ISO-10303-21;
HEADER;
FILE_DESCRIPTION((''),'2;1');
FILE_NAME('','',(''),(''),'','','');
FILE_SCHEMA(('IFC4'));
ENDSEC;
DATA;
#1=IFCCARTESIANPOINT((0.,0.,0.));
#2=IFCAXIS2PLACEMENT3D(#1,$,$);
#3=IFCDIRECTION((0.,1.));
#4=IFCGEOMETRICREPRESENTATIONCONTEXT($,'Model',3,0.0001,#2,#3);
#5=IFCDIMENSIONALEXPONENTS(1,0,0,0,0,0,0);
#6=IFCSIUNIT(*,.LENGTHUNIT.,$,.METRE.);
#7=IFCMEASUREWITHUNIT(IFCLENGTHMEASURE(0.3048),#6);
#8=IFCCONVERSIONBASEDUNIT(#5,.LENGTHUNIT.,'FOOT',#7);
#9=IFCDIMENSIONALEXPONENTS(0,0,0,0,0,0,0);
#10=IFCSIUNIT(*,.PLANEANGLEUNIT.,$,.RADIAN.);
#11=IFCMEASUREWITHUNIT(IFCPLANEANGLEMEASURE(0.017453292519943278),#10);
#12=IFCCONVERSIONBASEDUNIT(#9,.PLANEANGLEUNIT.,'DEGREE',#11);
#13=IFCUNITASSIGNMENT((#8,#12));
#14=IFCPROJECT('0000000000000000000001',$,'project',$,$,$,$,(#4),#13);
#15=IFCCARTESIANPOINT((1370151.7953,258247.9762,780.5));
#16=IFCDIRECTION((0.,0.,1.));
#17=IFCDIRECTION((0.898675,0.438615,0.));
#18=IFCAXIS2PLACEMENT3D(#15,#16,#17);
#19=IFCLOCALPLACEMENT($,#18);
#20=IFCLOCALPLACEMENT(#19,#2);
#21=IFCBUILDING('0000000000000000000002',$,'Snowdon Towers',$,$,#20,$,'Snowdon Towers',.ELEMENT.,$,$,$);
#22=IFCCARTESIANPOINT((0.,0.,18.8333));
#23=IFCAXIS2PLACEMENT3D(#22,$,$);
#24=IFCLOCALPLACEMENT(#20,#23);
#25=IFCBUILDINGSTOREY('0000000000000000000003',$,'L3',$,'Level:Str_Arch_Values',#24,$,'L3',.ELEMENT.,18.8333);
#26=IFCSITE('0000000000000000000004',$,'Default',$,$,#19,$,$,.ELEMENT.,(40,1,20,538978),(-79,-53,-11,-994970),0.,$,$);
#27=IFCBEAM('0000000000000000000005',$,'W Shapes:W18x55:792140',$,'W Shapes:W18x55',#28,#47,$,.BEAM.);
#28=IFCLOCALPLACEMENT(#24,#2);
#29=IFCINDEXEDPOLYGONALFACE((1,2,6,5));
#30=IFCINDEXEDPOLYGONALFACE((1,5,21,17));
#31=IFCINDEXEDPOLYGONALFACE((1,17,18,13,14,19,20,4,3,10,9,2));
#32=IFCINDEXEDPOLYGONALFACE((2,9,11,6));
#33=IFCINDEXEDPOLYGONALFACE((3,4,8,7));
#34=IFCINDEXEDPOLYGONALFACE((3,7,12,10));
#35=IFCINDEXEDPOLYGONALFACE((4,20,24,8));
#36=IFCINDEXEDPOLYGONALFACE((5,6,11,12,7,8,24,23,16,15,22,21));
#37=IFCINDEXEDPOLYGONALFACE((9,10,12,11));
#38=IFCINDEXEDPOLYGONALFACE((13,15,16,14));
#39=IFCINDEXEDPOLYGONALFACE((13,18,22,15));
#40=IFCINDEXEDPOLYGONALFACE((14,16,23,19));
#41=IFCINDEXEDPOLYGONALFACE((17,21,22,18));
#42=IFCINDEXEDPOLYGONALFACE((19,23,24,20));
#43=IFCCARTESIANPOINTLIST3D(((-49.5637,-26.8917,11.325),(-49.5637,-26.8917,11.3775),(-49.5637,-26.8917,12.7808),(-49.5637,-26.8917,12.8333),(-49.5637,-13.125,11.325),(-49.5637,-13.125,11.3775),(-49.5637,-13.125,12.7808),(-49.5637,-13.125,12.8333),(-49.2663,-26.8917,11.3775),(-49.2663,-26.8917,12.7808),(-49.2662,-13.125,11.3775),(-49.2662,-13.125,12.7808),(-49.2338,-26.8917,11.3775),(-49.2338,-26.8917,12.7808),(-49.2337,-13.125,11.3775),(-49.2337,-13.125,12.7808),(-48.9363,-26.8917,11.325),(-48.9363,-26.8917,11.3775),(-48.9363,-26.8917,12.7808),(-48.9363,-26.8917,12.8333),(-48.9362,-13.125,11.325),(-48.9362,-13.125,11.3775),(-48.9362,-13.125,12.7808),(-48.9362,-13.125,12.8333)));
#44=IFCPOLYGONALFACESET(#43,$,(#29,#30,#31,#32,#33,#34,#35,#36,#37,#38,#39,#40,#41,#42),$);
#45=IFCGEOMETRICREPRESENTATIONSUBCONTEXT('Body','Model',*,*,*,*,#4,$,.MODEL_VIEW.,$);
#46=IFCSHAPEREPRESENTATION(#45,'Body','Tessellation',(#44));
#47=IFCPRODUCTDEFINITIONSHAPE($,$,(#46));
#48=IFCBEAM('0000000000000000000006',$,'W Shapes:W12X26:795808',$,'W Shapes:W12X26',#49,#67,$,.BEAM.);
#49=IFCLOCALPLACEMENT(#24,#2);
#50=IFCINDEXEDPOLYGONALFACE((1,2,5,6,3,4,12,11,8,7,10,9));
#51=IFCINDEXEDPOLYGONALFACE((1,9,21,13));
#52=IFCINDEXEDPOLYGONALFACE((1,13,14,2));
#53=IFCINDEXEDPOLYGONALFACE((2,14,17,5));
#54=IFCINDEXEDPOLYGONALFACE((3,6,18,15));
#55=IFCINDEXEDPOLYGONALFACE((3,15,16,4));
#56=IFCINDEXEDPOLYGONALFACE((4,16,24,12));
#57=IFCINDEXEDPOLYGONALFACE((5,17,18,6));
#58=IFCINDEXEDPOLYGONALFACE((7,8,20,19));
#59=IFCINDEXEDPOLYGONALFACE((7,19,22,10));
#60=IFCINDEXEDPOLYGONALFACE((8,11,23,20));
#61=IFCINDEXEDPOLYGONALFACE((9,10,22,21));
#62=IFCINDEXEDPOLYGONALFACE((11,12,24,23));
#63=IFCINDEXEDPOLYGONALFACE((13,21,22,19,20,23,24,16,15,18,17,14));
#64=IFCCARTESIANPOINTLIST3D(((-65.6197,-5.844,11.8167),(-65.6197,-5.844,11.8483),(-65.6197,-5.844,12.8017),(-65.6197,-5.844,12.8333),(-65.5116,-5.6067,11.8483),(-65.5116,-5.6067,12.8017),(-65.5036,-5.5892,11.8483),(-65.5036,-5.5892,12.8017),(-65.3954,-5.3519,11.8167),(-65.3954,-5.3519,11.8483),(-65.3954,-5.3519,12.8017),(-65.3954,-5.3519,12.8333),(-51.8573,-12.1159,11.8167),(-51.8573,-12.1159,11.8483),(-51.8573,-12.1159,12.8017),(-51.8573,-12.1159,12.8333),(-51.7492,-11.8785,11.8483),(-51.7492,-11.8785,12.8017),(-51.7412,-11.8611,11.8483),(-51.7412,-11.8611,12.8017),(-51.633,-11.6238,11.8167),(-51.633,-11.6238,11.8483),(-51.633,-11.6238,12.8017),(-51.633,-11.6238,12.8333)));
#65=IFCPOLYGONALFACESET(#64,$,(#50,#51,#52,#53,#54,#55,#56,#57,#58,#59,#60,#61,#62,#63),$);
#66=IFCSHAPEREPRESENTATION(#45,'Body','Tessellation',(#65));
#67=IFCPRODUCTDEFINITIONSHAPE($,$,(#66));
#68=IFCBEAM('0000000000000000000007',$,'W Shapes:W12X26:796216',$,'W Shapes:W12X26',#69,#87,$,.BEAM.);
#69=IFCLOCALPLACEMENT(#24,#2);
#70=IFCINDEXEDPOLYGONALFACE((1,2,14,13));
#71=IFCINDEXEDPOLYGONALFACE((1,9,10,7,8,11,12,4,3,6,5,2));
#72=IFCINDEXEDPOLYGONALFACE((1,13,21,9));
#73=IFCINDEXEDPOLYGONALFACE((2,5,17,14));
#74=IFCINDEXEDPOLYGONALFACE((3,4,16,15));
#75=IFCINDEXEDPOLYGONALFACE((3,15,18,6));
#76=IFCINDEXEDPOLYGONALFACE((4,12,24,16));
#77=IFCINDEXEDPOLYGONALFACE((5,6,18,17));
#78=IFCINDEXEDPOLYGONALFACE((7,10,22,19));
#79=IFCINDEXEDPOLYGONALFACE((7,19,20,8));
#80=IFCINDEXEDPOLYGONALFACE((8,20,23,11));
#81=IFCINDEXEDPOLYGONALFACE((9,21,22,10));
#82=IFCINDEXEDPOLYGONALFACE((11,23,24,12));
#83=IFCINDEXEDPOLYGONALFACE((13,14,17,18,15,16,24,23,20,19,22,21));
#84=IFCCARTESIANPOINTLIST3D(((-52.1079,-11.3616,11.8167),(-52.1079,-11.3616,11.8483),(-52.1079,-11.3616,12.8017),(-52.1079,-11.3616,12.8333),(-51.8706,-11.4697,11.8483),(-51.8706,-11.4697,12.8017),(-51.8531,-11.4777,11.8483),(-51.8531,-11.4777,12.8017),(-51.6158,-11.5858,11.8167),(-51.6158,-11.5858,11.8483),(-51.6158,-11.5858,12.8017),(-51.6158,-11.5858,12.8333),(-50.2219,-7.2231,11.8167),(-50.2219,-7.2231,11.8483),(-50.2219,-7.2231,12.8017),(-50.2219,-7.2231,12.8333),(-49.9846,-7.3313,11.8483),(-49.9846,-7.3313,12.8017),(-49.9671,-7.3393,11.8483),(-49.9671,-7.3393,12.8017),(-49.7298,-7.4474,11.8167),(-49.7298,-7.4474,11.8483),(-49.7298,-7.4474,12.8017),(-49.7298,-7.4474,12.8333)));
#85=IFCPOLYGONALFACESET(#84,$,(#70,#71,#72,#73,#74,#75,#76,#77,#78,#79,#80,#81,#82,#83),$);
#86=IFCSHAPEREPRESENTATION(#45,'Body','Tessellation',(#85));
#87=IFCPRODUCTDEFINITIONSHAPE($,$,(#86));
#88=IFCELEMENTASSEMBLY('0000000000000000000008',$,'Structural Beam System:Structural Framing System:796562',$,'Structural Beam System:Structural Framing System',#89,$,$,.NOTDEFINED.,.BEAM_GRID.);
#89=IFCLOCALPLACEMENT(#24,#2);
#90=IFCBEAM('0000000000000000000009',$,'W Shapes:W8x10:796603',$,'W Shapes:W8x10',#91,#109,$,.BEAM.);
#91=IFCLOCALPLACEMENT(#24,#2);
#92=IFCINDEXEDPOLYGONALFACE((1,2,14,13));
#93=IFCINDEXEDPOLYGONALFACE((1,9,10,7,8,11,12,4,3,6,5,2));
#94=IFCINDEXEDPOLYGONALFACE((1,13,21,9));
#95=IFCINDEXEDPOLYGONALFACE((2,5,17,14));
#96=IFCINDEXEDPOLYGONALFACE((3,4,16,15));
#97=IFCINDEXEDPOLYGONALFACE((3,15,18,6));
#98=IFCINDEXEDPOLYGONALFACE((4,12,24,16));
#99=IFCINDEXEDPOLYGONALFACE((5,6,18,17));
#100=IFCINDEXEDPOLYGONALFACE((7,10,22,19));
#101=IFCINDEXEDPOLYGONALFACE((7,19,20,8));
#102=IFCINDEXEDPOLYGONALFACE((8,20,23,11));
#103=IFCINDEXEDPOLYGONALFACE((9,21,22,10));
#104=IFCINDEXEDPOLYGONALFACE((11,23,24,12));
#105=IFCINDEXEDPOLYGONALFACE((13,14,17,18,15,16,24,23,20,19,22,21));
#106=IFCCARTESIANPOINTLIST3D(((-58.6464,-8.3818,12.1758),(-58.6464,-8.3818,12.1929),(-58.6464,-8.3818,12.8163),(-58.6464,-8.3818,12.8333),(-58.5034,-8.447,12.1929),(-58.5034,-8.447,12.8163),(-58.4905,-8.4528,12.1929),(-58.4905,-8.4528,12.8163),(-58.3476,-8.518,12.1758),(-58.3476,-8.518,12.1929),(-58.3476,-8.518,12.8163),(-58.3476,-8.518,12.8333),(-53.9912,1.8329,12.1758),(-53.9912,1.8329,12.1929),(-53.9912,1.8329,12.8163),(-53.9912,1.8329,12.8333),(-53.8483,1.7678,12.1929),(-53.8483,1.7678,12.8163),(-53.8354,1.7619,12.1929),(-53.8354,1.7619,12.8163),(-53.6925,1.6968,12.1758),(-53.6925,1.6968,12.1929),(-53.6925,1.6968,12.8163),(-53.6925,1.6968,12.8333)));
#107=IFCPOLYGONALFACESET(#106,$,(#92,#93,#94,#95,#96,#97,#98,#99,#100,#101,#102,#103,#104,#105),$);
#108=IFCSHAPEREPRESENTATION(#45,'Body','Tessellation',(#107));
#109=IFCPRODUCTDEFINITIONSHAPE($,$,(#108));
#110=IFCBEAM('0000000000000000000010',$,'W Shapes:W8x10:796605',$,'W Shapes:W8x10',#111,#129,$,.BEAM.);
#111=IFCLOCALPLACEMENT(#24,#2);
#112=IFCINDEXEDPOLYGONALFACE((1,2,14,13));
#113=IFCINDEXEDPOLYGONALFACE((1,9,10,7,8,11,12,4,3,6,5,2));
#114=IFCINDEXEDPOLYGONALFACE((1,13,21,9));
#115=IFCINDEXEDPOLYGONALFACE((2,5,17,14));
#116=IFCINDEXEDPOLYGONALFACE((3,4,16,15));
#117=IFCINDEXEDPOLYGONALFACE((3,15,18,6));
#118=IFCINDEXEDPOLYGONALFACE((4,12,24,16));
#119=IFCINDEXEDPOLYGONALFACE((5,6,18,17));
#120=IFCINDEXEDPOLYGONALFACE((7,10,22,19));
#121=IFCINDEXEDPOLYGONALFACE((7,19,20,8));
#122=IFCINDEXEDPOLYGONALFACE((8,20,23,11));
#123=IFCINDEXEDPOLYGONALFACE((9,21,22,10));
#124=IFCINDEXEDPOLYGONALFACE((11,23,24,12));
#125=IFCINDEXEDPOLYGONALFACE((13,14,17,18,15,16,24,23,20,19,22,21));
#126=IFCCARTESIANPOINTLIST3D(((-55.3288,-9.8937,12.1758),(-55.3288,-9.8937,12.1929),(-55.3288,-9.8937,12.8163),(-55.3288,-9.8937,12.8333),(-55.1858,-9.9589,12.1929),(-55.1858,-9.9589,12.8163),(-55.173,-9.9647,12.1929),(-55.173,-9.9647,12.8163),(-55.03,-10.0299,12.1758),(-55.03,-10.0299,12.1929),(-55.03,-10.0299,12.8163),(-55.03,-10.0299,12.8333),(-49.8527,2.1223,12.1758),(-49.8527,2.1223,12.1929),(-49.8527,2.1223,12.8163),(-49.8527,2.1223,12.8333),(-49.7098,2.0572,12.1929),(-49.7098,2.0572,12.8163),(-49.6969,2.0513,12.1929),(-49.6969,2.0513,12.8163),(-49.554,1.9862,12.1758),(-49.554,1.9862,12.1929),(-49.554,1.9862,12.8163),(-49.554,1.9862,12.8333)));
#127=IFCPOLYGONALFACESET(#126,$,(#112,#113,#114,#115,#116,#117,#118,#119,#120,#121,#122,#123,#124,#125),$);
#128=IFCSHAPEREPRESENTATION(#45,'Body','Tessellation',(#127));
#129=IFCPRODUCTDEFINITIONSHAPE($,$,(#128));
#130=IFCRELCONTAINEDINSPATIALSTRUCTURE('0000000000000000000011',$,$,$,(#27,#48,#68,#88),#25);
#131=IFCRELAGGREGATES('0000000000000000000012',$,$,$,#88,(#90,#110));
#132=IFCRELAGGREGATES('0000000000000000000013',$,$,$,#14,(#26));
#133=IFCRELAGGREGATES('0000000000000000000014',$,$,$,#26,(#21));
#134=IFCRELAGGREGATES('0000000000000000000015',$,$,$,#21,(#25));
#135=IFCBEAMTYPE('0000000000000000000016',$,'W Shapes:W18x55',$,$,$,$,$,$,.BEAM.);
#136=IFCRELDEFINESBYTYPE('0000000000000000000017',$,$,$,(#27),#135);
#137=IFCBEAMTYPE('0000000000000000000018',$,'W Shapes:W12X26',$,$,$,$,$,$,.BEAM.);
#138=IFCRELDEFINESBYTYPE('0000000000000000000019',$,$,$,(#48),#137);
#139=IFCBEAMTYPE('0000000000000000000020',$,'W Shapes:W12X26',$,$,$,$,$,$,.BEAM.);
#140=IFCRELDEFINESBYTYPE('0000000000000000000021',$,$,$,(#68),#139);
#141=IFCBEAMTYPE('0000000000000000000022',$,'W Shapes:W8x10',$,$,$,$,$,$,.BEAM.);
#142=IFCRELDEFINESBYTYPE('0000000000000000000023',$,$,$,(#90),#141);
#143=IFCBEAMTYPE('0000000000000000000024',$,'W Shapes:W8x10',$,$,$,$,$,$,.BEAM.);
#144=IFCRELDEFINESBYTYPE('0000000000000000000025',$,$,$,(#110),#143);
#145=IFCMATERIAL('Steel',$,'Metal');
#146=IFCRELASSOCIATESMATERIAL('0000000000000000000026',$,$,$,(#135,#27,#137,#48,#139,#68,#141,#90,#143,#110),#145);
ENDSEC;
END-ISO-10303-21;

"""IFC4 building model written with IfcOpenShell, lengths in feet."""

from ifc_helpers import new_model, entity, si_unit, converted_unit, direction, frame, origin, place, context, subcontext, project, spatial, indexed_curve, outline, extrude, source, transform, mapped, material, type_object, type_shapes, element, aggregate, save


model = new_model("IFC4")

# Units and contexts
model_context = context("Model", 3, precision=0.0001, world=origin(), true_north=direction((0.0, 1.0)))
body_context = subcontext(model_context, "Body", "Model", "MODEL_VIEW")
ifc_project = project(units=[converted_unit("LENGTHUNIT", "FOOT", entity("IfcLengthMeasure", 0.3048), si_unit("LENGTHUNIT", "METRE"), dimensions=[1, 0, 0, 0, 0, 0, 0]), converted_unit("PLANEANGLEUNIT", "DEGREE", entity("IfcPlaneAngleMeasure", 0.017453292519943278), si_unit("PLANEANGLEUNIT", "RADIAN"), dimensions=[0, 0, 0, 0, 0, 0, 0])], contexts=[model_context])

# Site, building, storey
site_placement = place(None, frame((1370151.7953, 258247.9762, 780.5), z_axis=(0.0, 0.0, 1.0), x_axis=(0.898675, 0.438615, 0.0)))
site = spatial("IfcSite", under=ifc_project, at=site_placement, Name="Default", CompositionType="ELEMENT", RefLatitude=(40, 1, 20, 538978), RefLongitude=(-79, -53, -11, -994970), RefElevation=0.0)
building_placement = place(site_placement, origin())
building = spatial("IfcBuilding", under=site, at=building_placement, Name="Snowdon Towers", LongName="Snowdon Towers", CompositionType="ELEMENT")
storey_placement = place(building_placement, frame((0.0, 0.0, 18.8333)))
storey = spatial("IfcBuildingStorey", under=building, at=storey_placement, Name="L3", ObjectType="Level:Str_Arch_Values", LongName="L3", CompositionType="ELEMENT", Elevation=18.8333)

# Shared definitions
ifc_material = material(Name="Steel", Category="Metal")

# Beam
beam_type_1 = type_object("IfcBeamType", Name="W Shapes:W18x55", PredefinedType="BEAM", material=ifc_material)
shared_shape_1 = source(origin(), body_context, "Body", "SweptSolid", [
    extrude(outline(indexed_curve([(-0.3138, -0.7017), (-0.3138, -0.7542), (0.3138, -0.7542), (0.3138, -0.7017), (0.0162, -0.7017), (0.0162, 0.7017), (0.3138, 0.7017), (0.3138, 0.7542), (-0.3137, 0.7542), (-0.3137, 0.7017), (-0.0163, 0.7017), (-0.0163, -0.7017), (-0.3138, -0.7017)], self_intersect=False)), frame((-7.2292, 0.0, 0.0), z_axis=(-1.0, 0.0, 0.0), x_axis=(0.0, -1.0, 0.0)), (0.0, 0.0, -1.0), 13.7667),
])
type_shapes(beam_type_1, [shared_shape_1])
beam_1_placement = place(storey_placement, frame((-49.25, -20.3542, 12.0792), z_axis=(0.0, 0.0, 1.0), x_axis=(0.0, -1.0, 0.0)))
element("IfcBeam", 1, at=beam_1_placement, inside=storey, type_object=beam_type_1, material=ifc_material, Name="W Shapes:W18x55:792140", ObjectType="W Shapes:W18x55", PredefinedType="BEAM", context=body_context, shape_type="MappedRepresentation", body=[
    mapped(shared_shape_1, transform((0.0, 0.0, 0.0), scale=1.0)),
])

# Beams
beam_type_2 = type_object("IfcBeamType", Name="W Shapes:W12X26", PredefinedType="BEAM", material=ifc_material)
shared_shape_2 = source(origin(), body_context, "Body", "SweptSolid", [
    extrude(outline(indexed_curve([(-0.2704, -0.4767), (-0.2704, -0.5083), (0.2704, -0.5083), (0.2704, -0.4767), (0.0096, -0.4767), (0.0096, 0.4767), (0.2704, 0.4767), (0.2704, 0.5083), (-0.2704, 0.5083), (-0.2704, 0.4767), (-0.0096, 0.4767), (-0.0096, -0.4767), (-0.2704, -0.4767)], self_intersect=False)), frame((-7.5621, 0.0, 0.0), z_axis=(-1.0, 0.0, 0.0), x_axis=(0.0, -1.0, 0.0)), (0.0, 0.0, -1.0), 15.1242),
])
type_shapes(beam_type_2, [shared_shape_2])
beam_2_placement = place(storey_placement, frame((-58.6264, -8.7339, 12.325), z_axis=(0.0, 0.0, 1.0), x_axis=(0.909961, -0.414693, 0.0)))
element("IfcBeam", 2, at=beam_2_placement, inside=storey, type_object=beam_type_2, material=ifc_material, Name="W Shapes:W12X26:795808", ObjectType="W Shapes:W12X26", PredefinedType="BEAM", context=body_context, shape_type="MappedRepresentation", body=[
    mapped(shared_shape_2, transform((0.0, 0.0, 0.0), scale=1.0)),
])
beam_type_3 = type_object("IfcBeamType", Name="W Shapes:W12X26", PredefinedType="BEAM", material=ifc_material)
shared_shape_3 = source(origin(), body_context, "Body", "SweptSolid", [
    extrude(outline(indexed_curve([(-0.2704, -0.4767), (-0.2704, -0.5083), (0.2704, -0.5083), (0.2704, -0.4767), (0.0096, -0.4767), (0.0096, 0.4767), (0.2704, 0.4767), (0.2704, 0.5083), (-0.2704, 0.5083), (-0.2704, 0.4767), (-0.0096, 0.4767), (-0.0096, -0.4767), (-0.2704, -0.4767)], self_intersect=False)), frame((-2.882, 0.0, 0.0), z_axis=(-1.0, 0.0, 0.0), x_axis=(0.0, -1.0, 0.0)), (0.0, 0.0, -1.0), 4.5479),
])
type_shapes(beam_type_3, [shared_shape_3])
beam_3_placement = place(storey_placement, frame((-50.6667, -8.8511, 12.325), z_axis=(0.0, 0.0, 1.0), x_axis=(0.414693, 0.909961, 0.0)))
element("IfcBeam", 3, at=beam_3_placement, inside=storey, type_object=beam_type_3, material=ifc_material, Name="W Shapes:W12X26:796216", ObjectType="W Shapes:W12X26", PredefinedType="BEAM", context=body_context, shape_type="MappedRepresentation", body=[
    mapped(shared_shape_3, transform((0.0, 0.0, 0.0), scale=1.0)),
])

# Element assembly, beams
assembly_1_placement = place(storey_placement, origin())
assembly_1 = element("IfcElementAssembly", 4, at=assembly_1_placement, inside=storey, Name="Structural Beam System:Structural Framing System:796562", ObjectType="Structural Beam System:Structural Framing System", AssemblyPlace="NOTDEFINED", PredefinedType="BEAM_GRID")
beam_type_4 = type_object("IfcBeamType", Name="W Shapes:W8x10", PredefinedType="BEAM", material=ifc_material)
shared_shape_4 = source(origin(), body_context, "Body", "SweptSolid", [
    extrude(outline(indexed_curve([(-0.1642, -0.3117), (-0.1642, -0.3288), (0.1642, -0.3288), (0.1642, -0.3117), (0.0071, -0.3117), (0.0071, 0.3117), (0.1642, 0.3117), (0.1642, 0.3287), (-0.1642, 0.3287), (-0.1642, 0.3117), (-0.0071, 0.3117), (-0.0071, -0.3117), (-0.1642, -0.3117)], self_intersect=False)), frame((-5.8606, 0.0, 0.0), z_axis=(-1.0, 0.0, 0.0), x_axis=(0.0, -1.0, 0.0)), (0.0, 0.0, -1.0), 11.2255),
])
type_shapes(beam_type_4, [shared_shape_4])
beam_4_placement = place(assembly_1_placement, frame((-56.0666, -3.1169, 12.5046), z_axis=(0.0, 0.0, 1.0), x_axis=(0.414693, 0.909961, 0.0)))
beam_4 = element("IfcBeam", 5, at=beam_4_placement, type_object=beam_type_4, material=ifc_material, Name="W Shapes:W8x10:796603", ObjectType="W Shapes:W8x10", PredefinedType="BEAM", context=body_context, shape_type="MappedRepresentation", body=[
    mapped(shared_shape_4, transform((0.0, 0.0, 0.0), scale=1.0)),
])
beam_type_5 = type_object("IfcBeamType", Name="W Shapes:W8x10", PredefinedType="BEAM", material=ifc_material)
shared_shape_5 = source(origin(), body_context, "Body", "SweptSolid", [
    extrude(outline(indexed_curve([(-0.1642, -0.3117), (-0.1642, -0.3288), (0.1642, -0.3288), (0.1642, -0.3117), (0.0071, -0.3117), (0.0071, 0.3117), (0.1642, 0.3117), (0.1642, 0.3287), (-0.1642, 0.3287), (-0.1642, 0.3117), (-0.0071, 0.3117), (-0.0071, -0.3117), (-0.1642, -0.3117)], self_intersect=False)), frame((-6.6914, 0.0, 0.0), z_axis=(-1.0, 0.0, 0.0), x_axis=(0.0, -1.0, 0.0)), (0.0, 0.0, -1.0), 13.205),
])
type_shapes(beam_type_5, [shared_shape_5])
beam_5_placement = place(assembly_1_placement, frame((-52.4045, -3.8729, 12.5046), z_axis=(0.0, 0.0, 1.0), x_axis=(0.414693, 0.909961, 0.0)))
beam_5 = element("IfcBeam", 6, at=beam_5_placement, type_object=beam_type_5, material=ifc_material, Name="W Shapes:W8x10:796605", ObjectType="W Shapes:W8x10", PredefinedType="BEAM", context=body_context, shape_type="MappedRepresentation", body=[
    mapped(shared_shape_5, transform((0.0, 0.0, 0.0), scale=1.0)),
])
aggregate(assembly_1, [beam_4, beam_5])

save(model, "model.ifc")
